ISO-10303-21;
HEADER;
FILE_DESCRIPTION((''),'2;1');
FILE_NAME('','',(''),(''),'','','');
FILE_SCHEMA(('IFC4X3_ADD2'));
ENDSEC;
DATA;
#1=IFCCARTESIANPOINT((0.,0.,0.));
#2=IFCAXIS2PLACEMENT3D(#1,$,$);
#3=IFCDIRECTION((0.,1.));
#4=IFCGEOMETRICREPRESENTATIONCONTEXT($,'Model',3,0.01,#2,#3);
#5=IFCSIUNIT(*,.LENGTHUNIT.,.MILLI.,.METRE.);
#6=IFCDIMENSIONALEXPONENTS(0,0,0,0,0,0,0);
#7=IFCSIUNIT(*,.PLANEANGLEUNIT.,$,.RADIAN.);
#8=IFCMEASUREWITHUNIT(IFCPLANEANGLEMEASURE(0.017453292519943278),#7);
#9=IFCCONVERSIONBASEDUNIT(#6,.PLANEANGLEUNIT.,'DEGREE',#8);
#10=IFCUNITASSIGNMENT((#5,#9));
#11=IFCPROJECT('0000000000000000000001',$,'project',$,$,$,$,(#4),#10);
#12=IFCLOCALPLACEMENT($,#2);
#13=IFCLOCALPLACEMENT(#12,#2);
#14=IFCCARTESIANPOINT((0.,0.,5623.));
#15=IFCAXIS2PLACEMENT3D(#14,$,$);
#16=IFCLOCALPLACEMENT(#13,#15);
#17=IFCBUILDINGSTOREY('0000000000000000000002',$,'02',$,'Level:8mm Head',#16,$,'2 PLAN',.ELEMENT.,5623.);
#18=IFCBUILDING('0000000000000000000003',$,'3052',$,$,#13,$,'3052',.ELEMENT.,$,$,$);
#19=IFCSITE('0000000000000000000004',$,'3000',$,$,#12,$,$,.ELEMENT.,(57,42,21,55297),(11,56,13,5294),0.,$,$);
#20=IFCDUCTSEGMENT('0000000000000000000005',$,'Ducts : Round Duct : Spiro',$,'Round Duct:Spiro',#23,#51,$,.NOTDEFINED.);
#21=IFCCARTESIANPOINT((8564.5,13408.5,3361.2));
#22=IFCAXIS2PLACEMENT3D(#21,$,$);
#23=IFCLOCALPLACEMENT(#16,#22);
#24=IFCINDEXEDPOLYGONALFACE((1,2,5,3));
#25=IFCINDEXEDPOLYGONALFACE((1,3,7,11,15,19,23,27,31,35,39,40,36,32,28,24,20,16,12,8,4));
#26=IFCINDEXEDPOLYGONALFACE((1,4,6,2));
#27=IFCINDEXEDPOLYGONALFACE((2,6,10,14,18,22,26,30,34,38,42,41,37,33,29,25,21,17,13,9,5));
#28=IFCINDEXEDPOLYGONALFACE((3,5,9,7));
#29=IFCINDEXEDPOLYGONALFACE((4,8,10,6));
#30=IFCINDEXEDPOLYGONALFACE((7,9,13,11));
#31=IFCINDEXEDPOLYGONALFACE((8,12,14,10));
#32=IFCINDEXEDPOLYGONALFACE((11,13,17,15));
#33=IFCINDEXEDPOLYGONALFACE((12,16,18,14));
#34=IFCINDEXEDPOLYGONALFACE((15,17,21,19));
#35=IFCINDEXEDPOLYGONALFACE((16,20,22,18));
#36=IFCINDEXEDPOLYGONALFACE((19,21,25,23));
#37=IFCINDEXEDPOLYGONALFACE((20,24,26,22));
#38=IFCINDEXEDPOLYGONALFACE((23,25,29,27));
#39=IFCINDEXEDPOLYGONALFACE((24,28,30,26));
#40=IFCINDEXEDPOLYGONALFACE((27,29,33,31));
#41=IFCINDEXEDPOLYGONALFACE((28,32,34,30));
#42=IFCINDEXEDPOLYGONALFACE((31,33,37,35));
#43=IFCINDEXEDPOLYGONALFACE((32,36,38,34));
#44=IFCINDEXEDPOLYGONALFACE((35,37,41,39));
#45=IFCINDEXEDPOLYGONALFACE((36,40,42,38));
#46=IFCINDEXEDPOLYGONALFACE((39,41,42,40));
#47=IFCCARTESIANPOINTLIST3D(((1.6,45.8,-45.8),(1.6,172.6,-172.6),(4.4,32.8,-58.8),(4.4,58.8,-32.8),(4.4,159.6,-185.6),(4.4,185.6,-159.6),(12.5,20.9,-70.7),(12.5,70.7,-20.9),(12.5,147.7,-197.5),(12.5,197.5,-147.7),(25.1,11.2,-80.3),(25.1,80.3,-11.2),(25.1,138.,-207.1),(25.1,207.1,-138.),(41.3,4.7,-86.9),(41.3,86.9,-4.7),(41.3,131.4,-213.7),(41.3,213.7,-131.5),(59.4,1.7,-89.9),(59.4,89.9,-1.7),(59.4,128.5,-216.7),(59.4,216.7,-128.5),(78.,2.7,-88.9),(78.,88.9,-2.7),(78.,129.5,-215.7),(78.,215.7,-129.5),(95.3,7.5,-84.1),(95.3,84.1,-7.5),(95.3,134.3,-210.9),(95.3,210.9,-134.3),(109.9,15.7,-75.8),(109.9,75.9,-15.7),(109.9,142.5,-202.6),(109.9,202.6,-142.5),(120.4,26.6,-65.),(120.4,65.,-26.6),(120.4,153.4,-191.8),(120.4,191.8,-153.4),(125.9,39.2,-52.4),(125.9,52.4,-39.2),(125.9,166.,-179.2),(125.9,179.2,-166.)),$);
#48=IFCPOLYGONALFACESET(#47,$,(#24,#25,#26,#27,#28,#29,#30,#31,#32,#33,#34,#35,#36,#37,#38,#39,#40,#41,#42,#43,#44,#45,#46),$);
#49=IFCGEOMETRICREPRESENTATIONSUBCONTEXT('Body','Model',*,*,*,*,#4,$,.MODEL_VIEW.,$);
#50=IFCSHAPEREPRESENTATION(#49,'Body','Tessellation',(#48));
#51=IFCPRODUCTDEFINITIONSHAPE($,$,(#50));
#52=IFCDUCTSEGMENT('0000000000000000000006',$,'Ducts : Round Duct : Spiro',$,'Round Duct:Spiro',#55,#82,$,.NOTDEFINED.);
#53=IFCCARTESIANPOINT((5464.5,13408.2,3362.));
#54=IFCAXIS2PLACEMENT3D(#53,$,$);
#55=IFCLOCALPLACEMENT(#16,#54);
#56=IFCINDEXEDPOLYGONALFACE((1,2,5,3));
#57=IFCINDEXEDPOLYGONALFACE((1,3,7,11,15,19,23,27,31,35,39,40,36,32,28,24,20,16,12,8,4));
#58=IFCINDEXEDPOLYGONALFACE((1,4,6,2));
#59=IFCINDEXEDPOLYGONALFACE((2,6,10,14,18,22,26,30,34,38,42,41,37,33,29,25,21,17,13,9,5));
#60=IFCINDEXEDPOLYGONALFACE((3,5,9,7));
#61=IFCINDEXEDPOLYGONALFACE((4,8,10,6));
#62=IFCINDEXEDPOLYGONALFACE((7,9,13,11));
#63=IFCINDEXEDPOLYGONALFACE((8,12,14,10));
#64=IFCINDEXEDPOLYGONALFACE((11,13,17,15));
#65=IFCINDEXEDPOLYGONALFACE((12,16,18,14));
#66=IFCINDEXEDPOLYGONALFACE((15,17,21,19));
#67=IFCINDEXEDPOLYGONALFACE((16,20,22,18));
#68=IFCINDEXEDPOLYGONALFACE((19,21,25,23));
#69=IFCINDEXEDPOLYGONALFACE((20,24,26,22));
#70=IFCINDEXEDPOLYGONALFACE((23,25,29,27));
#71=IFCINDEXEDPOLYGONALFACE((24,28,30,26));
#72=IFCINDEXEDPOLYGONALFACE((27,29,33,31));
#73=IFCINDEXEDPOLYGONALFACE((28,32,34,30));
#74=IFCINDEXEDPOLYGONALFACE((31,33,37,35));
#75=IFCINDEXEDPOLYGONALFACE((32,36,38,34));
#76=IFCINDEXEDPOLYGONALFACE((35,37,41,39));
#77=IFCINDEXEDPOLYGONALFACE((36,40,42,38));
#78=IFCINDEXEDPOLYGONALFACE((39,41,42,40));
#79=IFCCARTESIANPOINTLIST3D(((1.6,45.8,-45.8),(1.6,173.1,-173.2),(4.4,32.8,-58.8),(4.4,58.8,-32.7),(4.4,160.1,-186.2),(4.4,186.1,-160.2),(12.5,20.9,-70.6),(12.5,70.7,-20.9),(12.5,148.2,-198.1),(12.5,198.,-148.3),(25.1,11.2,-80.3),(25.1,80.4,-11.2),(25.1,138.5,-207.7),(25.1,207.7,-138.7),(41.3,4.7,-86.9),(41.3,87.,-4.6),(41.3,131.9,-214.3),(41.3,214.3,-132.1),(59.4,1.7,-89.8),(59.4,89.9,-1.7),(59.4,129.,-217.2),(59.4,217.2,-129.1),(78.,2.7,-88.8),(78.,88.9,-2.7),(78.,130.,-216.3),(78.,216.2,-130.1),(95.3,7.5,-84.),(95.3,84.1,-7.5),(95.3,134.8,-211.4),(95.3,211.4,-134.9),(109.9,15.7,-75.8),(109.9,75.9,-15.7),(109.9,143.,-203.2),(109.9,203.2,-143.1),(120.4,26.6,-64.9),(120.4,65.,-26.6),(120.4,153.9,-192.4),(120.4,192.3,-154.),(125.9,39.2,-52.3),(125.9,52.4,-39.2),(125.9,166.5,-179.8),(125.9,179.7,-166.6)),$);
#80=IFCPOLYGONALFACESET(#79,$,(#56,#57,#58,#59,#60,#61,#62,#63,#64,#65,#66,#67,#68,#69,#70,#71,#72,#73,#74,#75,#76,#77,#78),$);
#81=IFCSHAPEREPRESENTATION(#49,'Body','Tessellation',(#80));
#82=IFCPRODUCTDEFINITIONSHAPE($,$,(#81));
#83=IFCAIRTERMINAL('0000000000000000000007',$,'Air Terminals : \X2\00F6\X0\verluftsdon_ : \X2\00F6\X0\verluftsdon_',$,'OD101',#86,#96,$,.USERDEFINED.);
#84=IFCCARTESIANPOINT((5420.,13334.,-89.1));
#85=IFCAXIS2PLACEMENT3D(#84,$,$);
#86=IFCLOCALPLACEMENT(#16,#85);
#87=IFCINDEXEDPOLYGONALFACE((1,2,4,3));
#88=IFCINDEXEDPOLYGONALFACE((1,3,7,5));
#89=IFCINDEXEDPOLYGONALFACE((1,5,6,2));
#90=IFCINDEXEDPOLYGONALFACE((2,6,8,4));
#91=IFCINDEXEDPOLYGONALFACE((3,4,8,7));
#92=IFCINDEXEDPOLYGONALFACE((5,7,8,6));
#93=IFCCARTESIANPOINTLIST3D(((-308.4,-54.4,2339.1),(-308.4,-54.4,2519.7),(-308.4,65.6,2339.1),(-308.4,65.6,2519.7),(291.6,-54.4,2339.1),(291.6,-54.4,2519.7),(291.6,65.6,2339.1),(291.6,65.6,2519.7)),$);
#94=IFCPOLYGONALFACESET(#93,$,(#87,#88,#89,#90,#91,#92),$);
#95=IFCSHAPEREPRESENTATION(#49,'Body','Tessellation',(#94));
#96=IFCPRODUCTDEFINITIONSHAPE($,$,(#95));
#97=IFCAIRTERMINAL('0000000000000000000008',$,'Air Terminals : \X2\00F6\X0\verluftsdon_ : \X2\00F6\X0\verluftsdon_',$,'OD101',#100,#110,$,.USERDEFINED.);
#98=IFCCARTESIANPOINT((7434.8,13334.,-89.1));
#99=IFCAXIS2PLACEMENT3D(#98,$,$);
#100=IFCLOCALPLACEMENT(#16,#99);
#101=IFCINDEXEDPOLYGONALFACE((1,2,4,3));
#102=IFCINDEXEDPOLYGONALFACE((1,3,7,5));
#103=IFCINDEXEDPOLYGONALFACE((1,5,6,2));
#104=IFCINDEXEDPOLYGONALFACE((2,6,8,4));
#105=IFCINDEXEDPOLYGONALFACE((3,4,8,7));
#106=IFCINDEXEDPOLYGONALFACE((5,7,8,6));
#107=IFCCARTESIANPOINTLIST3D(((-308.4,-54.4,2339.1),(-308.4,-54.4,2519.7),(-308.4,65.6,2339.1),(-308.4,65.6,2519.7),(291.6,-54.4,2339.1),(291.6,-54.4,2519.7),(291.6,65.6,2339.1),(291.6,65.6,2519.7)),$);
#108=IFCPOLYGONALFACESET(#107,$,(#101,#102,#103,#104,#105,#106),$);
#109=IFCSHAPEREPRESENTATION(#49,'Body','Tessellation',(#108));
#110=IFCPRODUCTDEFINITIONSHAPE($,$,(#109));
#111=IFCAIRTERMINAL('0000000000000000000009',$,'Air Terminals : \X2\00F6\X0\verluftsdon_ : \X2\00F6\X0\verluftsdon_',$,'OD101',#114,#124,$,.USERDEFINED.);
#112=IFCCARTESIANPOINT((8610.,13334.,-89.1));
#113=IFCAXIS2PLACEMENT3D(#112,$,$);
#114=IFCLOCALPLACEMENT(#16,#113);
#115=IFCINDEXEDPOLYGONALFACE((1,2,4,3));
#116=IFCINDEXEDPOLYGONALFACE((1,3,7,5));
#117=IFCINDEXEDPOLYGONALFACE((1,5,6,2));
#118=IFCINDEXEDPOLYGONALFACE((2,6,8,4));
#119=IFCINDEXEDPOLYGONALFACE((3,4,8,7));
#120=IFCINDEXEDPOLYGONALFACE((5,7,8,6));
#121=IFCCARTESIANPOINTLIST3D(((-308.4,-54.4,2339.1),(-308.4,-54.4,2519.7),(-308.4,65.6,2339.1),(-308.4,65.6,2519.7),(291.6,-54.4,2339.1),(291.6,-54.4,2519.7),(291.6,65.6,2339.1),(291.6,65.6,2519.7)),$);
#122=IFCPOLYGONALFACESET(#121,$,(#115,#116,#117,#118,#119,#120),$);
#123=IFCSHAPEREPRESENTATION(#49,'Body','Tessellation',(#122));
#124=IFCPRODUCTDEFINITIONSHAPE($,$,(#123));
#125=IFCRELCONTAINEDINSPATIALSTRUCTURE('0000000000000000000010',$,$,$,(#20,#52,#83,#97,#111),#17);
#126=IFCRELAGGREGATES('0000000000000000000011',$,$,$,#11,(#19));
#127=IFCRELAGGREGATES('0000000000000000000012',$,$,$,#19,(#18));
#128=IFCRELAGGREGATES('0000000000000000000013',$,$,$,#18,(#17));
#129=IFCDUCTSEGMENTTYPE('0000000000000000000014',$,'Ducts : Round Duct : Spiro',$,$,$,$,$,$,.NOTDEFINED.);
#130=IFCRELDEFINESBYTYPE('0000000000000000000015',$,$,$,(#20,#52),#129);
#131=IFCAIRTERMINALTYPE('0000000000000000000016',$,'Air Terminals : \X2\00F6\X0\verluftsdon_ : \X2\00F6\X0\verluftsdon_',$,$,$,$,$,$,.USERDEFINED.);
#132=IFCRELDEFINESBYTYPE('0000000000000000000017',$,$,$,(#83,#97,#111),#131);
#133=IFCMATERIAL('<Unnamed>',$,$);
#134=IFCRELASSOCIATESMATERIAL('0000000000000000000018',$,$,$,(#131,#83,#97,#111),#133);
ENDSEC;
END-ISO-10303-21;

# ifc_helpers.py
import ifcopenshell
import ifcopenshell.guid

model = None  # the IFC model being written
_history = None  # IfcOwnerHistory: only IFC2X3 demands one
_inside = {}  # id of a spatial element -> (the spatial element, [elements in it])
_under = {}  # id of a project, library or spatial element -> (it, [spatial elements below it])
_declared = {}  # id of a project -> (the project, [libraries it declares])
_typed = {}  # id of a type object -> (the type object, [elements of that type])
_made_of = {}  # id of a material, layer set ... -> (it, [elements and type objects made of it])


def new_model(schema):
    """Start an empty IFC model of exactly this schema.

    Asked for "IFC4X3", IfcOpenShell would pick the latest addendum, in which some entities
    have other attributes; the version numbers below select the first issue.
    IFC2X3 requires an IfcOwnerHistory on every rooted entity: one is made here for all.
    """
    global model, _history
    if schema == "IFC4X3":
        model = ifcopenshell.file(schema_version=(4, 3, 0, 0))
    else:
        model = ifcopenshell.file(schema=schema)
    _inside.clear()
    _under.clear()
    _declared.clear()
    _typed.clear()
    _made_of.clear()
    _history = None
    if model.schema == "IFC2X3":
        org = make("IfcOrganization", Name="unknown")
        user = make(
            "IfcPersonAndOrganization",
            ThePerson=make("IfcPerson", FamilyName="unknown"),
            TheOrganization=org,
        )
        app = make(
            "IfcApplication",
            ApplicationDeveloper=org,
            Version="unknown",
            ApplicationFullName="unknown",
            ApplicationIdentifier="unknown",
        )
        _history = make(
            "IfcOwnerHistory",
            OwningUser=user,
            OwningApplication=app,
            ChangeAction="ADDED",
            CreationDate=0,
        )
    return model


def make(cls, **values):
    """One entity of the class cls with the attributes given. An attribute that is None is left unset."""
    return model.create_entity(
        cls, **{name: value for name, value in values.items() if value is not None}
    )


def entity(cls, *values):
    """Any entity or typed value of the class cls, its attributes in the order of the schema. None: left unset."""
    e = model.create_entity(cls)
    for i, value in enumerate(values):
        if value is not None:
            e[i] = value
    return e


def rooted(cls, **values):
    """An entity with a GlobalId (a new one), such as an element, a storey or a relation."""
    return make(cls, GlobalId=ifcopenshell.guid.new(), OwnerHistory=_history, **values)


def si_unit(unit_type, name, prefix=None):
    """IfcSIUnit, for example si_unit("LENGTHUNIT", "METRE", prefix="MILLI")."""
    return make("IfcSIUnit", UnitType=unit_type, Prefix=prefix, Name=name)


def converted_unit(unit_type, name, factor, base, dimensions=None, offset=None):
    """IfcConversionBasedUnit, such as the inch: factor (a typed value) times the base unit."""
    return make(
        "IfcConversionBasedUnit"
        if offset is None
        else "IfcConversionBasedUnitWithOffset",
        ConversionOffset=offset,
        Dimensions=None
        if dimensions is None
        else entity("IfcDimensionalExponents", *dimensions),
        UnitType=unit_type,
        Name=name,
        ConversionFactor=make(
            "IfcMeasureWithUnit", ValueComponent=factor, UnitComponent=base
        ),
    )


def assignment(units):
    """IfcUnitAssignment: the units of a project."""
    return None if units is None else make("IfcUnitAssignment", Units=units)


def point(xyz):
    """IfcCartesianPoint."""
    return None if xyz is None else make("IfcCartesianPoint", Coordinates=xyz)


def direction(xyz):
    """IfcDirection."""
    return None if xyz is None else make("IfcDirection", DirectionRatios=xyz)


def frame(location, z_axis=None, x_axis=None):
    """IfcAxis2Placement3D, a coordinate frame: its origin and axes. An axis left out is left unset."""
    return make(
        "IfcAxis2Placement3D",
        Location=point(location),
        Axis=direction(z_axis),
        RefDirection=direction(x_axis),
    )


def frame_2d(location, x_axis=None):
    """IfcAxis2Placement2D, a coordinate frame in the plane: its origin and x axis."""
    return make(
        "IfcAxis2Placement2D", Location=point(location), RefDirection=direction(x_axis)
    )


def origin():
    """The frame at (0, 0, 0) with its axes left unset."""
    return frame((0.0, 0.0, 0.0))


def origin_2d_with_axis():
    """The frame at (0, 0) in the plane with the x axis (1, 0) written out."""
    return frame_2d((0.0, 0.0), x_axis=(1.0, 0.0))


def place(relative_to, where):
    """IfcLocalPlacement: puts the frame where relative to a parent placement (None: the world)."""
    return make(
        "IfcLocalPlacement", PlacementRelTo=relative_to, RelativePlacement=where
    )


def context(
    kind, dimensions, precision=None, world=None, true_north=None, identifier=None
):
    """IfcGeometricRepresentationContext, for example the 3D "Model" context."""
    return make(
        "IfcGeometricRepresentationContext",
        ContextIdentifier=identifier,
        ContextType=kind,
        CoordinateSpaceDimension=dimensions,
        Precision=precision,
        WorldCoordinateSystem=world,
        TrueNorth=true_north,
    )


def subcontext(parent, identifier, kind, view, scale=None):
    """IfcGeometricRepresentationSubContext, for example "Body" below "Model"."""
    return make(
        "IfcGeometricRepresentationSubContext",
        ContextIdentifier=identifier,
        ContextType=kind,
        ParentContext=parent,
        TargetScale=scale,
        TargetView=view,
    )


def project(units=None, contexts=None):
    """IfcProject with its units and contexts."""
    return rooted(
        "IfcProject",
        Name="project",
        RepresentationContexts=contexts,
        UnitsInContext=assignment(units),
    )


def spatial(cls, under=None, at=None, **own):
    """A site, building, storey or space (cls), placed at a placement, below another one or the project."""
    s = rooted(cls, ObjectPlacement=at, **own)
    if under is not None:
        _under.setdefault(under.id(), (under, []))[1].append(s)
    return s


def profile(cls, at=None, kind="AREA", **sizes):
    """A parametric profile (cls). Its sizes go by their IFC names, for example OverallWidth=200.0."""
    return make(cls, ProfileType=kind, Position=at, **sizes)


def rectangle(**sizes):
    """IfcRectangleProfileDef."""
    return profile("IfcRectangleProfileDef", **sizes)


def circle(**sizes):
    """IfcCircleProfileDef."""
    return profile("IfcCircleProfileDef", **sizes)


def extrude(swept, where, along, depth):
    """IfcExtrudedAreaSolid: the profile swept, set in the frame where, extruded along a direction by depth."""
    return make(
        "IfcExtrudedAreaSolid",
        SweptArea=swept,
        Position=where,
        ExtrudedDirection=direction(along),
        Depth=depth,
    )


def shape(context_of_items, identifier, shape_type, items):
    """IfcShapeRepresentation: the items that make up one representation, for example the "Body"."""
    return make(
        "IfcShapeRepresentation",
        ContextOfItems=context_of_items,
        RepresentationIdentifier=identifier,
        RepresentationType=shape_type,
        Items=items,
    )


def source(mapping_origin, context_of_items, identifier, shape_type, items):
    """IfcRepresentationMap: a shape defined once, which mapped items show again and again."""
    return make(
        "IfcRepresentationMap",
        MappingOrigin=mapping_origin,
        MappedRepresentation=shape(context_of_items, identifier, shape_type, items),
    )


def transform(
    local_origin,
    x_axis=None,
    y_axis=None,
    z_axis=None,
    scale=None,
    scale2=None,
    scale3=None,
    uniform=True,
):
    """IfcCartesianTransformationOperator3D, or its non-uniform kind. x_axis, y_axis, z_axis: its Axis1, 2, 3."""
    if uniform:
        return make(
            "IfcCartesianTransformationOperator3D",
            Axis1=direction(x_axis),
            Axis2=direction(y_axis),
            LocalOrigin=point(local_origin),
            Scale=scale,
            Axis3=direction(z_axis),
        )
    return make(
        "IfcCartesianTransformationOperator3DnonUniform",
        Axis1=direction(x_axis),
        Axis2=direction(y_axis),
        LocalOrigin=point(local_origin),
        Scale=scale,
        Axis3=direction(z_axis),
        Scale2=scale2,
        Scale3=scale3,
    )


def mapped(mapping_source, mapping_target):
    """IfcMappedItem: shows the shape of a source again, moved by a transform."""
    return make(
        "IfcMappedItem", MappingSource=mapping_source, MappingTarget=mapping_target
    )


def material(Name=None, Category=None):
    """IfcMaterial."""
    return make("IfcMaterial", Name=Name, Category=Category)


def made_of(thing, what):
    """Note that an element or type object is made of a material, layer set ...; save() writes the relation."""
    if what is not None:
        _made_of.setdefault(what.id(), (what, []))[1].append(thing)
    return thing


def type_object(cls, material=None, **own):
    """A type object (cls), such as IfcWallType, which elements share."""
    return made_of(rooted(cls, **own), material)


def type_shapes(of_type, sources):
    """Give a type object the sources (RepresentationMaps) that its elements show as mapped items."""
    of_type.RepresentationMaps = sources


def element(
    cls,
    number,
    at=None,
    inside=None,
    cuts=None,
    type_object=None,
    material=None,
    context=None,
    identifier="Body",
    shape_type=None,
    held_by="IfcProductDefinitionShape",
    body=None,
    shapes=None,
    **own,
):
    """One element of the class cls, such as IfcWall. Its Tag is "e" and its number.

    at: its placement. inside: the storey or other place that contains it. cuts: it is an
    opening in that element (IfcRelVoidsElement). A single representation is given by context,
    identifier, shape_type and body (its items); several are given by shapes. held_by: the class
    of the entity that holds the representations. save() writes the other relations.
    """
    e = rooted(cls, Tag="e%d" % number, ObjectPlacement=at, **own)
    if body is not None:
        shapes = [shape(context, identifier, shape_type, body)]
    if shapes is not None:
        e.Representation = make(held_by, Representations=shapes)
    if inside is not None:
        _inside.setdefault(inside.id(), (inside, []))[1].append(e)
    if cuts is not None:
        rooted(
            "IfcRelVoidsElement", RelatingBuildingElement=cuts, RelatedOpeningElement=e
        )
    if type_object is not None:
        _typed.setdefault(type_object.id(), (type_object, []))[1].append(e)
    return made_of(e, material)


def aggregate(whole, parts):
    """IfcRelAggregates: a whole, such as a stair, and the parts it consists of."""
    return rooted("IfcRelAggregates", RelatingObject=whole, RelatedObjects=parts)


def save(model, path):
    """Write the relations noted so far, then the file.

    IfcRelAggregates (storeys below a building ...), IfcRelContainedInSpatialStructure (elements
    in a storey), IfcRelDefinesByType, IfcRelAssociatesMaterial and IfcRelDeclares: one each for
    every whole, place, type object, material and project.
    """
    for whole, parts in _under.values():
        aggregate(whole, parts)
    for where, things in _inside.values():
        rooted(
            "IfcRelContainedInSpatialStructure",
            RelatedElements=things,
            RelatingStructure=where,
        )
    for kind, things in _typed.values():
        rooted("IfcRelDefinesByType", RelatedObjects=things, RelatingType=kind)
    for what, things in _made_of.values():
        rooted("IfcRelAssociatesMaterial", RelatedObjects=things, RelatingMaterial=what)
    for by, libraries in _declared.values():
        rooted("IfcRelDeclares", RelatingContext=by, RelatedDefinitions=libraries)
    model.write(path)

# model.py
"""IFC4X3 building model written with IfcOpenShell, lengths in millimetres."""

from ifc_helpers import new_model, entity, si_unit, converted_unit, direction, frame, frame_2d, origin, origin_2d_with_axis, place, context, subcontext, project, spatial, rectangle, circle, extrude, source, transform, mapped, material, type_object, type_shapes, element, save


model = new_model("IFC4X3")

# Units and contexts
model_context = context("Model", 3, precision=0.01, world=origin(), true_north=direction((0.0, 1.0)))
body_context = subcontext(model_context, "Body", "Model", "MODEL_VIEW")
ifc_project = project(units=[si_unit("LENGTHUNIT", "METRE", prefix="MILLI"), converted_unit("PLANEANGLEUNIT", "DEGREE", entity("IfcPlaneAngleMeasure", 0.017453292519943278), si_unit("PLANEANGLEUNIT", "RADIAN"), dimensions=[0, 0, 0, 0, 0, 0, 0])], contexts=[model_context])

# Site, building, storey
site_placement = place(None, origin())
site = spatial("IfcSite", under=ifc_project, at=site_placement, Name="3000", CompositionType="ELEMENT", RefLatitude=(57, 42, 21, 55297), RefLongitude=(11, 56, 13, 5294), RefElevation=0.0)
building_placement = place(site_placement, origin())
building = spatial("IfcBuilding", under=site, at=building_placement, Name="3052", LongName="3052", CompositionType="ELEMENT")
storey_placement = place(building_placement, frame((0.0, 0.0, 5623.0)))
storey = spatial("IfcBuildingStorey", under=building, at=storey_placement, Name="02", ObjectType="Level:8mm Head", LongName="2 PLAN", CompositionType="ELEMENT", Elevation=5623.0)

# Duct segments
duct_segment_type = type_object("IfcDuctSegmentType", Name="Ducts : Round Duct : Spiro", PredefinedType="NOTDEFINED")
duct_segment_1_placement = place(storey_placement, frame((8564.5, 13408.5, 3361.2)))
element("IfcDuctSegment", 1, at=duct_segment_1_placement, inside=storey, type_object=duct_segment_type, Name="Ducts : Round Duct : Spiro", ObjectType="Round Duct:Spiro", PredefinedType="NOTDEFINED", context=body_context, shape_type="SweptSolid", body=[
    extrude(circle(Radius=62.5, at=frame_2d((0.0, 0.0), x_axis=(1.0, 0.0))), frame((64.1, 45.8, -45.8), z_axis=(0.0, 0.707093, -0.707121), x_axis=(-1.0, 0.0, 0.0)), (0.0, 0.0, 1.0), 179.3),
])
duct_segment_2_placement = place(storey_placement, frame((5464.5, 13408.2, 3362.0)))
element("IfcDuctSegment", 2, at=duct_segment_2_placement, inside=storey, type_object=duct_segment_type, Name="Ducts : Round Duct : Spiro", ObjectType="Round Duct:Spiro", PredefinedType="NOTDEFINED", context=body_context, shape_type="SweptSolid", body=[
    extrude(circle(Radius=62.5, at=frame_2d((0.0, 0.0), x_axis=(1.0, 0.0))), frame((64.1, 45.8, -45.8), z_axis=(0.0, 0.706725, -0.707488), x_axis=(-1.0, 0.0, 0.0)), (0.0, 0.0, 1.0), 180.1),
])

# Air terminals
ifc_material_1 = material(Name="<Unnamed>")
air_terminal_type_1 = type_object("IfcAirTerminalType", Name="Air Terminals : överluftsdon_ : överluftsdon_", PredefinedType="USERDEFINED", material=ifc_material_1)
shared_shape_1 = source(origin(), body_context, "Body", "SweptSolid", [
    extrude(rectangle(XDim=600.0, YDim=120.0, at=origin_2d_with_axis()), frame((-8.4, 5.6, 2339.1), z_axis=(0.0, 0.0, 1.0), x_axis=(-1.0, 0.0, 0.0)), (0.0, 0.0, 1.0), 180.7),
])
type_shapes(air_terminal_type_1, [shared_shape_1])
for number, where, name in (
    (3, (5420.0, 13334.0, -89.1), "Air Terminals : överluftsdon_ : överluftsdon_"),
    (4, (7434.8, 13334.0, -89.1), "Air Terminals : överluftsdon_ : överluftsdon_"),
    (5, (8610.0, 13334.0, -89.1), "Air Terminals : överluftsdon_ : överluftsdon_"),
):
    element("IfcAirTerminal", number, at=place(storey_placement, frame(where)), inside=storey, type_object=air_terminal_type_1, material=ifc_material_1, Name=name, ObjectType="OD101", PredefinedType="USERDEFINED", context=body_context, shape_type="MappedRepresentation", body=[
        mapped(shared_shape_1, transform((0.0, 0.0, 0.0), scale=1.0)),
    ])

save(model, "model.ifc")
